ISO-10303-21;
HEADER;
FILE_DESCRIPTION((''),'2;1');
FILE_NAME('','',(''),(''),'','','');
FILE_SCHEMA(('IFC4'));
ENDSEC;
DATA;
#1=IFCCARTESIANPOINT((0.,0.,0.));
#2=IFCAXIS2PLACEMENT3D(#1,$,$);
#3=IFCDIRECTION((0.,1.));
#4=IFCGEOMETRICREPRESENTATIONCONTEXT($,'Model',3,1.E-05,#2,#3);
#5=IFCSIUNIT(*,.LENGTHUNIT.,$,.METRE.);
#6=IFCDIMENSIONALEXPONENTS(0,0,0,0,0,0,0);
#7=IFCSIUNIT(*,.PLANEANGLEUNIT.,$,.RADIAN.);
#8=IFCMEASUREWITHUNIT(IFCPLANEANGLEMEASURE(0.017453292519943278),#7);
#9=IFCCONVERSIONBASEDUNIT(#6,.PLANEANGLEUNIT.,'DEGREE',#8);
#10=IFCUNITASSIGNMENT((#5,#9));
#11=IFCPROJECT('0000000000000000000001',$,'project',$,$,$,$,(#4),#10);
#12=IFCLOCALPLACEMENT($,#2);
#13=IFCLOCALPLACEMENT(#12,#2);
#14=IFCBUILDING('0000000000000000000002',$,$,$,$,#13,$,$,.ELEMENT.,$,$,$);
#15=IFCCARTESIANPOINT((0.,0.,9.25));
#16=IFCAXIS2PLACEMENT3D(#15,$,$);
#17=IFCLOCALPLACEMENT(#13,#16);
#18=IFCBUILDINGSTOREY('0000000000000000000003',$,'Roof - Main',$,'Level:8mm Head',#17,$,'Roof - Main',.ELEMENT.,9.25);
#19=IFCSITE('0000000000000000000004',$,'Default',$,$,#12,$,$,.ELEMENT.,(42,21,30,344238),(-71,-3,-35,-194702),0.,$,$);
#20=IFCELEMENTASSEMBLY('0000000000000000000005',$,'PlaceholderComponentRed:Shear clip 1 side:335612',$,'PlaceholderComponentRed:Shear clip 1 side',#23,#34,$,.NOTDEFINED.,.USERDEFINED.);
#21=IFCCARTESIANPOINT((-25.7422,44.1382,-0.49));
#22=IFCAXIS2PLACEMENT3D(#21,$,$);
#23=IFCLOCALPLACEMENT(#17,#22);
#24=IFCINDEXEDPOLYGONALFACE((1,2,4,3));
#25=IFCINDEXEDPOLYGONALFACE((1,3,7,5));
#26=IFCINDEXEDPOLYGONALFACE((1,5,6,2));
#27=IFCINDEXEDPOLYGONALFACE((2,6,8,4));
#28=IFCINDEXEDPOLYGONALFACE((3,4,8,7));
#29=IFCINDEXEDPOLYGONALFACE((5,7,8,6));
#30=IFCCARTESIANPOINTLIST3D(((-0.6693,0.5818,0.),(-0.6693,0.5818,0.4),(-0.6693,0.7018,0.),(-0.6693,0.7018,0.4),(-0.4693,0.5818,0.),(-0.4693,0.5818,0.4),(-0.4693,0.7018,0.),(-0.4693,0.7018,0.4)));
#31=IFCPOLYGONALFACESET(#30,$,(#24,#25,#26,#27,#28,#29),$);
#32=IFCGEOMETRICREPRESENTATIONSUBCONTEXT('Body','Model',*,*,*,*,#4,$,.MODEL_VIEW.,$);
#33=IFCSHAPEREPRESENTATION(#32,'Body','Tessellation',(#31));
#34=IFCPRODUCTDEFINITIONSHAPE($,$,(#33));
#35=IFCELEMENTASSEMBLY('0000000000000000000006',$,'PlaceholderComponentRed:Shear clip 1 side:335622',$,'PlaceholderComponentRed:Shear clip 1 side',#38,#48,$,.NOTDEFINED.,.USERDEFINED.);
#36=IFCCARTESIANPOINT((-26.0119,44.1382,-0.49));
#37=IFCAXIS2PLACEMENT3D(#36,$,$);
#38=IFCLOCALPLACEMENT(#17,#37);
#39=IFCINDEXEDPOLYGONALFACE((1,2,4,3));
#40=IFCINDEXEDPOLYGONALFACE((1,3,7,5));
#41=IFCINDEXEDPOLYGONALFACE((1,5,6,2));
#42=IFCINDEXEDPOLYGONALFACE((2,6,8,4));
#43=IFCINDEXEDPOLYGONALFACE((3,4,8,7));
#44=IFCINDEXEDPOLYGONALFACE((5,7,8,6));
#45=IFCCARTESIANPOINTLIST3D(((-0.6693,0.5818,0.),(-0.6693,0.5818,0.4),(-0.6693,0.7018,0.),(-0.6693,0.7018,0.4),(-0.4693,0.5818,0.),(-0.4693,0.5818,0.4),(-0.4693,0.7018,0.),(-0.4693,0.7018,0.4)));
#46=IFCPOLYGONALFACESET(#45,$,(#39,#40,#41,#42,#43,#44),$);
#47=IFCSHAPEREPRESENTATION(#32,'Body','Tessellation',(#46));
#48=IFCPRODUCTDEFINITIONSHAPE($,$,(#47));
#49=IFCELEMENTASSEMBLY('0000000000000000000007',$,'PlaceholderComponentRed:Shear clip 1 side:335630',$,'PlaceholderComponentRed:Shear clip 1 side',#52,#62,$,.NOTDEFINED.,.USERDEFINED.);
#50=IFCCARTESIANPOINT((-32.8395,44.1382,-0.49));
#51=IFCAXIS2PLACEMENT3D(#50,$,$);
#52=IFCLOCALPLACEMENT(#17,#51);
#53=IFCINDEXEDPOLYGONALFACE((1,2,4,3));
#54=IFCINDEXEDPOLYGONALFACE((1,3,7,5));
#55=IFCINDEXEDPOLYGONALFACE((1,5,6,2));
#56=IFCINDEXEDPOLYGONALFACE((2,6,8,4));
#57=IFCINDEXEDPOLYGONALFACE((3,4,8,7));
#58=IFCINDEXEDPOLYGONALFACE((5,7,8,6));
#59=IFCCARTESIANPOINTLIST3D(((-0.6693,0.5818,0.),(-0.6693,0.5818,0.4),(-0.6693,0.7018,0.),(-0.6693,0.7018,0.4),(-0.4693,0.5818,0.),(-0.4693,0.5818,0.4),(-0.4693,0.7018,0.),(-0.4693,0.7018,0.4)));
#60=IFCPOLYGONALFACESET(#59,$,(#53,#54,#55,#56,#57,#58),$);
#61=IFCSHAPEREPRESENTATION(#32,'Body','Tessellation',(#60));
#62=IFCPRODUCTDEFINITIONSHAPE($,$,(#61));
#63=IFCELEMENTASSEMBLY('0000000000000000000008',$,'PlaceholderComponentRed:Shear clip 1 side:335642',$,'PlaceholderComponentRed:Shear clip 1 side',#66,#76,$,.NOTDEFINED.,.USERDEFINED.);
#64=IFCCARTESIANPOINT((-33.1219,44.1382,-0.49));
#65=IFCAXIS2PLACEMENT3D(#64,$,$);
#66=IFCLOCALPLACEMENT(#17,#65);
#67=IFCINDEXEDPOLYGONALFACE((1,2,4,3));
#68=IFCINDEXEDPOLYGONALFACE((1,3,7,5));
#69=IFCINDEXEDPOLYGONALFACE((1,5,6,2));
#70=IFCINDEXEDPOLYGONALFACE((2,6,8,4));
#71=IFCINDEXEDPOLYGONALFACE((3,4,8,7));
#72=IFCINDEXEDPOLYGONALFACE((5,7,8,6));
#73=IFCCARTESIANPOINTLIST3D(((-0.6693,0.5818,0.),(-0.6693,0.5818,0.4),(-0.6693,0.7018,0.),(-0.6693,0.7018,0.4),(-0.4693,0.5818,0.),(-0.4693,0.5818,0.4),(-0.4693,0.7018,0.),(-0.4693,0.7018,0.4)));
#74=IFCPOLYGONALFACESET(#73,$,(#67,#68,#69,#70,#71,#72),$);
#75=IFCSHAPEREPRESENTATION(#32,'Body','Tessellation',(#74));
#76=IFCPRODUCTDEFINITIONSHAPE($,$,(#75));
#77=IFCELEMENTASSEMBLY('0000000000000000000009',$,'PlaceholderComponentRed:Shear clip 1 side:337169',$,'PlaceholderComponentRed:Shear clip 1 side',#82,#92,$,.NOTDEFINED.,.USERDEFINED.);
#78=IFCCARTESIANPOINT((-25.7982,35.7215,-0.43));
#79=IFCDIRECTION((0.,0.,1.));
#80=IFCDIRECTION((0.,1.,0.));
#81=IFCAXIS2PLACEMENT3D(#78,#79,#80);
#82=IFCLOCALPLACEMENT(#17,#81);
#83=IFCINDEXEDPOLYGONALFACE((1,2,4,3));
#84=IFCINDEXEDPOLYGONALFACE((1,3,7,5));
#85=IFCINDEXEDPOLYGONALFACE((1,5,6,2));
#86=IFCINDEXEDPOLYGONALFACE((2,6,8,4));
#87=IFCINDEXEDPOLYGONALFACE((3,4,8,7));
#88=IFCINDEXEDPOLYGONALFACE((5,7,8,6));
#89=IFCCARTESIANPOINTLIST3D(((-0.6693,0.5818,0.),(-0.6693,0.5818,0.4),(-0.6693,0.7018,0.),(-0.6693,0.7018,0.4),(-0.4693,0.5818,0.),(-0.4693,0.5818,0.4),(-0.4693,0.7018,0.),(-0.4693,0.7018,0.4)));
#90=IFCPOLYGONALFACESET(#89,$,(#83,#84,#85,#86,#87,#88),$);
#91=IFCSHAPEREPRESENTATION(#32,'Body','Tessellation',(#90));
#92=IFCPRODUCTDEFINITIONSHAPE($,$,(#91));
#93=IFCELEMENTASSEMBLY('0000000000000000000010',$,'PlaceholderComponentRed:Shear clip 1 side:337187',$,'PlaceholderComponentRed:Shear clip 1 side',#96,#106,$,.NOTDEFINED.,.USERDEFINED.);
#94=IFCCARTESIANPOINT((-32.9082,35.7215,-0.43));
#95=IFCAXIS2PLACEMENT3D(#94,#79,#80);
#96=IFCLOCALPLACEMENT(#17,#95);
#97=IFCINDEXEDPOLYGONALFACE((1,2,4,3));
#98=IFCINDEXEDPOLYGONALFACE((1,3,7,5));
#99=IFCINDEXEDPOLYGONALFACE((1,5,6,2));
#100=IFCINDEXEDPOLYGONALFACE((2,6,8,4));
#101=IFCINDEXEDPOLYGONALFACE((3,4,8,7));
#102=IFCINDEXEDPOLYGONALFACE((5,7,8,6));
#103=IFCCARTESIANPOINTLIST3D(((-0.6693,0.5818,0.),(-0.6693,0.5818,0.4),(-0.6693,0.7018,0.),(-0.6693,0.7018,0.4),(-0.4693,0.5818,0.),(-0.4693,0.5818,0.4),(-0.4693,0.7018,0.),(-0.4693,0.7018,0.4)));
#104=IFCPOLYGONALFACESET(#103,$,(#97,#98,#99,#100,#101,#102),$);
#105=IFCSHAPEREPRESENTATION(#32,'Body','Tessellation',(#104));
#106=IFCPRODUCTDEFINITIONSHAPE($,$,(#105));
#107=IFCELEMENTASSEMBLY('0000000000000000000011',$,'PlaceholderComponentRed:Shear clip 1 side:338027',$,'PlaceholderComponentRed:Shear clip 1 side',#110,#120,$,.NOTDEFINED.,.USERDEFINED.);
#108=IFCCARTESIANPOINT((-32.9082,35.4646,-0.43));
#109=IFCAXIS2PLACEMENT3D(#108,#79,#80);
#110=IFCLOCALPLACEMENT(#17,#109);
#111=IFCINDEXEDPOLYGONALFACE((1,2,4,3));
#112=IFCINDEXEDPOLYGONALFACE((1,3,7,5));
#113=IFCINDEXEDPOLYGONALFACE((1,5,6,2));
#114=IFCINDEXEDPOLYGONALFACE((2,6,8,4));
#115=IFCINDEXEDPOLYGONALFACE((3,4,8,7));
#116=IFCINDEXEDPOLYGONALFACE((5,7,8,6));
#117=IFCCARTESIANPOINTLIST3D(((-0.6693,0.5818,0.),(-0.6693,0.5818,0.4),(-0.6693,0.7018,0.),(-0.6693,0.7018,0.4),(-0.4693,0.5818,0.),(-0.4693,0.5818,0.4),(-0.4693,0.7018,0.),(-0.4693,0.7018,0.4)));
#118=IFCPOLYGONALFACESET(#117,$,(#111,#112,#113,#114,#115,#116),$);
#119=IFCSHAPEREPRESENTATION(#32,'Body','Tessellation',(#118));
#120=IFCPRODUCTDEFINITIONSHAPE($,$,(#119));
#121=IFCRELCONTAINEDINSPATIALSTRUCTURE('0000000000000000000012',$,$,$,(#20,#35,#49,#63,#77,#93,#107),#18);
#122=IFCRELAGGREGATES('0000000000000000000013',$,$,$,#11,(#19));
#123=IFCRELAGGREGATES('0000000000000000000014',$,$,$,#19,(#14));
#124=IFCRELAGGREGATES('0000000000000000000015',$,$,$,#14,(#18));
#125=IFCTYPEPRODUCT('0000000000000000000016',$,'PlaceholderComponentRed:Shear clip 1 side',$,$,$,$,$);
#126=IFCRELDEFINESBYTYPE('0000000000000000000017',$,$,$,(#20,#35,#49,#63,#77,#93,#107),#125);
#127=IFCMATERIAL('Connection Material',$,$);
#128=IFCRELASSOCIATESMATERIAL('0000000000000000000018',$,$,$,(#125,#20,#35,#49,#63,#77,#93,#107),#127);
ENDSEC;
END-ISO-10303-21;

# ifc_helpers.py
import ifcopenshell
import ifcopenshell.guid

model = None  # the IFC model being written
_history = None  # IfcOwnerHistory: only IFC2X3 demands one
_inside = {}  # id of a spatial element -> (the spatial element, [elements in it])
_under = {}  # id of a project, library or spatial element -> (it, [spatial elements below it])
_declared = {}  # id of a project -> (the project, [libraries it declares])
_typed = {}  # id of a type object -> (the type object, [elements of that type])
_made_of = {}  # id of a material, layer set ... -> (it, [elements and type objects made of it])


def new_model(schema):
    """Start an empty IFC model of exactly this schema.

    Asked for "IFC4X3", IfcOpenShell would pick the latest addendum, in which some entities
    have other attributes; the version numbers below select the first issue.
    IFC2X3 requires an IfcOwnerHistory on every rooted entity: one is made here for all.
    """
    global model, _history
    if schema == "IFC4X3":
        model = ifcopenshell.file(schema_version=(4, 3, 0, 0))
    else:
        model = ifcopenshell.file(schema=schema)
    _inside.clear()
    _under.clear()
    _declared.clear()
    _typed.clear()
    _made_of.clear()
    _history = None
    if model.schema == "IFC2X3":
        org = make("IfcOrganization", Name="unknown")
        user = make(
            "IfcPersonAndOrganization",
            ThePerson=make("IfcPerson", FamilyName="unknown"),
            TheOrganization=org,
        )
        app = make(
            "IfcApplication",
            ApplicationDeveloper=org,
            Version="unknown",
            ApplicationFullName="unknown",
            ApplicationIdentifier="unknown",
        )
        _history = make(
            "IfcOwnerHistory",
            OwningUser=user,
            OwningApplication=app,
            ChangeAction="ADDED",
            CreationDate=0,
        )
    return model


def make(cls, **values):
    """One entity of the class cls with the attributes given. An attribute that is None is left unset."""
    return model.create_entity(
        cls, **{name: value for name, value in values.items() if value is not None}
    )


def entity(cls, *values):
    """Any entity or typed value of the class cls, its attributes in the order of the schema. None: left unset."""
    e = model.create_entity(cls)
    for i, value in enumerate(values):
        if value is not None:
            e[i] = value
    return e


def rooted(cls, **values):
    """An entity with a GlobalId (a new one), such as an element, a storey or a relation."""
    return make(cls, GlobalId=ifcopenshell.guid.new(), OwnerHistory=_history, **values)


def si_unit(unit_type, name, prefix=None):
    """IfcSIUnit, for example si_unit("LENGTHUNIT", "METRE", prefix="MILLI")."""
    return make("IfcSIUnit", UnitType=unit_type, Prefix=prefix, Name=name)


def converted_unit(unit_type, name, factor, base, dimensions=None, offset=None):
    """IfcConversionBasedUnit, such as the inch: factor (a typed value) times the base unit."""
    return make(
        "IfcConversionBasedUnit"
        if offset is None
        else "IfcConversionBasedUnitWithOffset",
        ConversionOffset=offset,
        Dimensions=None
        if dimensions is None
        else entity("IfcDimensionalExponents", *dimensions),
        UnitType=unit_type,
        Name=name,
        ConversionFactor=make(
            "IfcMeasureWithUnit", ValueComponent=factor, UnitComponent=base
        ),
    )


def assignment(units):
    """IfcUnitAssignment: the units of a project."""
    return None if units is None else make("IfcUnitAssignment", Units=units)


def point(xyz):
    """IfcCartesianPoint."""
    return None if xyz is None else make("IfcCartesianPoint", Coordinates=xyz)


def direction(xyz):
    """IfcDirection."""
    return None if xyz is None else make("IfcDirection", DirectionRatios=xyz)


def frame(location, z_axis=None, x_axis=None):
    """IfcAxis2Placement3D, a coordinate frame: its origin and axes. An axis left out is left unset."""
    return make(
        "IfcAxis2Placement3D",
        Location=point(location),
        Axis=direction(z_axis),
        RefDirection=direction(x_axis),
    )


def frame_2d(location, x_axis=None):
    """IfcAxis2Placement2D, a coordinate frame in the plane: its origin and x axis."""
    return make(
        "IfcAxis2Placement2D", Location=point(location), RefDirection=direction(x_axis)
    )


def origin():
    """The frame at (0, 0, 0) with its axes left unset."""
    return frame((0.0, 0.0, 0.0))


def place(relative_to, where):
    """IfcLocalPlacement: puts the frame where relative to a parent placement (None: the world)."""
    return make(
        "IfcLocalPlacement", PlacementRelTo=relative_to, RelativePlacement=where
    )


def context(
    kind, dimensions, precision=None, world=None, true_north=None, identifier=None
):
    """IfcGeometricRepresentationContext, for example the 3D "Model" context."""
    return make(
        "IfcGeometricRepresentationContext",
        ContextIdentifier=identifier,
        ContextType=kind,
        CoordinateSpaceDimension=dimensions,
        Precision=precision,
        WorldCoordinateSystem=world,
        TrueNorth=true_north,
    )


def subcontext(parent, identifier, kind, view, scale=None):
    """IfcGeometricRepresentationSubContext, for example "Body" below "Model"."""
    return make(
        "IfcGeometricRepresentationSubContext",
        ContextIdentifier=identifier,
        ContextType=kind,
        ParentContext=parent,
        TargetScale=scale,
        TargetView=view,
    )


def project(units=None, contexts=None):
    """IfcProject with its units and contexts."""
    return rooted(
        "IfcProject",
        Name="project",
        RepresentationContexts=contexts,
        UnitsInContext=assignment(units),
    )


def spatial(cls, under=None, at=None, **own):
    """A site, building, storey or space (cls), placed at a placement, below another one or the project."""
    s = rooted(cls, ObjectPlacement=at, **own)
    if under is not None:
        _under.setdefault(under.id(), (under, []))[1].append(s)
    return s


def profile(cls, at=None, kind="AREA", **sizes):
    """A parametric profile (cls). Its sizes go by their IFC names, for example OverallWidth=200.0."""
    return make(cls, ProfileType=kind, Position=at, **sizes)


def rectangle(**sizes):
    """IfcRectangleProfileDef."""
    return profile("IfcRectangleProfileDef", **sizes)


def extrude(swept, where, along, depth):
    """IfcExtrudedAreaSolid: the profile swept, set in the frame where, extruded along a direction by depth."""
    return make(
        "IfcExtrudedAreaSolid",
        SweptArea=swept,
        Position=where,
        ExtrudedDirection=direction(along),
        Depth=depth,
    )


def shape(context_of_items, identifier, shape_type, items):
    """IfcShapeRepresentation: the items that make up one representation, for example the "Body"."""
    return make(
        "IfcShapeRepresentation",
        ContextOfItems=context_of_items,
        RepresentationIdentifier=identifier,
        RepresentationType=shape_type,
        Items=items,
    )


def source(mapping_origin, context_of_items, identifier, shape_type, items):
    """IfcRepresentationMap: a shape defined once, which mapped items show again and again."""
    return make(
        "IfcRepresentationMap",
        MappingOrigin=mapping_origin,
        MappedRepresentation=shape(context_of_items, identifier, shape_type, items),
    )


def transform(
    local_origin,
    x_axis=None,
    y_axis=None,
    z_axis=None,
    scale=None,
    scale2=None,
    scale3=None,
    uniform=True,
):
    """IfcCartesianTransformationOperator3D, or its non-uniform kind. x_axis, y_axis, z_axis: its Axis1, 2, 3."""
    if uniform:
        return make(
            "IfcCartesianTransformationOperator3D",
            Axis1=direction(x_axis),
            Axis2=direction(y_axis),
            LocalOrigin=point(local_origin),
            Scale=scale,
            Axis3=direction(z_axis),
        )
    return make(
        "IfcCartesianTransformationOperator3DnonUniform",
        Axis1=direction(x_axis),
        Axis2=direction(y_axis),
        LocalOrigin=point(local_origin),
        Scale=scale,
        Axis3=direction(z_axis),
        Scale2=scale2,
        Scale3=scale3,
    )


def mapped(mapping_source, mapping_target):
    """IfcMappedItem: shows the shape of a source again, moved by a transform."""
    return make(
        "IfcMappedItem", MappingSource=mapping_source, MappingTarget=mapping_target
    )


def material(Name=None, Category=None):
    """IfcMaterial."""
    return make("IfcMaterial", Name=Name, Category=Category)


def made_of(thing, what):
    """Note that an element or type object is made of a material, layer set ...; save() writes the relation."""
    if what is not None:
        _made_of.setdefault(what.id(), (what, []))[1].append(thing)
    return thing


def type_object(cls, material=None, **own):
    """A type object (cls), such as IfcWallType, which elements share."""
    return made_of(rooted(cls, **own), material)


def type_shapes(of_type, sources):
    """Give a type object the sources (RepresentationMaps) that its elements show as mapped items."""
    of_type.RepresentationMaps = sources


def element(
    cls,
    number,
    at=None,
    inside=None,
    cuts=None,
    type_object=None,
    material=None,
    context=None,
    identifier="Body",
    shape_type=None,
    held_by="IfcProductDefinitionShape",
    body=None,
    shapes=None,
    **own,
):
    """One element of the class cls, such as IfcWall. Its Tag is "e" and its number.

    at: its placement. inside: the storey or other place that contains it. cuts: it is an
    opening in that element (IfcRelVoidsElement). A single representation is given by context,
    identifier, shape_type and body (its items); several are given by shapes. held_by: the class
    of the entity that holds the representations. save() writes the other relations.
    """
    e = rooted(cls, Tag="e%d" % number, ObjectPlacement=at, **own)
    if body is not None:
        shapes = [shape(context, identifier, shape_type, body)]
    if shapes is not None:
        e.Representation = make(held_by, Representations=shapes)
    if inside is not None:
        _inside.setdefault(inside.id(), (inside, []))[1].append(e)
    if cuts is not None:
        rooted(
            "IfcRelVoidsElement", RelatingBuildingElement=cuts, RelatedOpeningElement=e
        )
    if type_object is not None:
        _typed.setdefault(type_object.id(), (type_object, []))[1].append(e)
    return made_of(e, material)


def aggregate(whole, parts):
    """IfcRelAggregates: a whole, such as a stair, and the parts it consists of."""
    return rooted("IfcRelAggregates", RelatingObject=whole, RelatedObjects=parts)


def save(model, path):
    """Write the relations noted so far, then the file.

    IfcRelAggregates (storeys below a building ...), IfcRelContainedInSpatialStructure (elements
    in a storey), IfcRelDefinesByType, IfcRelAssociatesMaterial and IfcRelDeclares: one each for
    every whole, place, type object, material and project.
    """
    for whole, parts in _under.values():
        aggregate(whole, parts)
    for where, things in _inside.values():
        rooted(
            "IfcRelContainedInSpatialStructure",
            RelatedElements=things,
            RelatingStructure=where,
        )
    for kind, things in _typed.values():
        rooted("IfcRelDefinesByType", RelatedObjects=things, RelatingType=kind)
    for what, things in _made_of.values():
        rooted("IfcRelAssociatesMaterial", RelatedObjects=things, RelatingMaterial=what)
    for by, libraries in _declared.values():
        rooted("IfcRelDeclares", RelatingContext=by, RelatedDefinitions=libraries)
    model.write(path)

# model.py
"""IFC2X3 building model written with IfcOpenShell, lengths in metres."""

from ifc_helpers import new_model, entity, si_unit, converted_unit, direction, frame, frame_2d, origin, place, context, subcontext, project, spatial, rectangle, extrude, source, transform, mapped, material, type_object, type_shapes, element, save


model = new_model("IFC2X3")

# Units and contexts
model_context = context("Model", 3, precision=1e-05, world=origin(), true_north=direction((0.0, 1.0)))
body_context = subcontext(model_context, "Body", "Model", "MODEL_VIEW")
ifc_project = project(units=[si_unit("LENGTHUNIT", "METRE"), converted_unit("PLANEANGLEUNIT", "DEGREE", entity("IfcPlaneAngleMeasure", 0.017453292519943278), si_unit("PLANEANGLEUNIT", "RADIAN"), dimensions=[0, 0, 0, 0, 0, 0, 0])], contexts=[model_context])

# Site, building, storey
site_placement = place(None, origin())
site = spatial("IfcSite", under=ifc_project, at=site_placement, Name="Default", CompositionType="ELEMENT", RefLatitude=(42, 21, 30, 344238), RefLongitude=(-71, -3, -35, -194702), RefElevation=0.0)
building_placement = place(site_placement, origin())
building = spatial("IfcBuilding", under=site, at=building_placement, CompositionType="ELEMENT")
storey_placement = place(building_placement, frame((0.0, 0.0, 9.25)))
storey = spatial("IfcBuildingStorey", under=building, at=storey_placement, Name="Roof - Main", ObjectType="Level:8mm Head", LongName="Roof - Main", CompositionType="ELEMENT", Elevation=9.25)

# Element assemblies
ifc_material_1 = material(Name="Connection Material")
type_product = type_object("IfcTypeProduct", Name="PlaceholderComponentRed:Shear clip 1 side", material=ifc_material_1)
shared_shape_1 = source(origin(), body_context, "Body", "SweptSolid", [
    extrude(rectangle(XDim=0.12, YDim=0.2, at=frame_2d((0.0, 0.0), x_axis=(1.0, 0.0))), frame((-0.5693, 0.6418, 0.0), z_axis=(0.0, 0.0, 1.0), x_axis=(0.0, 1.0, 0.0)), (0.0, 0.0, 1.0), 0.4),
])
type_shapes(type_product, [shared_shape_1])
for number, where, name in (
    (1, (-25.7422, 44.1382, -0.49), "PlaceholderComponentRed:Shear clip 1 side:335612"),
    (2, (-26.0119, 44.1382, -0.49), "PlaceholderComponentRed:Shear clip 1 side:335622"),
    (3, (-32.8395, 44.1382, -0.49), "PlaceholderComponentRed:Shear clip 1 side:335630"),
    (4, (-33.1219, 44.1382, -0.49), "PlaceholderComponentRed:Shear clip 1 side:335642"),
):
    element("IfcElementAssembly", number, at=place(storey_placement, frame(where)), inside=storey, type_object=type_product, material=ifc_material_1, Name=name, ObjectType="PlaceholderComponentRed:Shear clip 1 side", AssemblyPlace="NOTDEFINED", PredefinedType="USERDEFINED", context=body_context, shape_type="MappedRepresentation", body=[
        mapped(shared_shape_1, transform((0.0, 0.0, 0.0), scale=1.0)),
    ])
for number, where, z_axis, x_axis, name in (
    (5, (-25.7982, 35.7215, -0.43), (0.0, 0.0, 1.0), (0.0, 1.0, 0.0), "PlaceholderComponentRed:Shear clip 1 side:337169"),
    (6, (-32.9082, 35.7215, -0.43), (0.0, 0.0, 1.0), (0.0, 1.0, 0.0), "PlaceholderComponentRed:Shear clip 1 side:337187"),
    (7, (-32.9082, 35.4646, -0.43), (0.0, 0.0, 1.0), (0.0, 1.0, 0.0), "PlaceholderComponentRed:Shear clip 1 side:338027"),
):
    element("IfcElementAssembly", number, at=place(storey_placement, frame(where, z_axis=z_axis, x_axis=x_axis)), inside=storey, type_object=type_product, material=ifc_material_1, Name=name, ObjectType="PlaceholderComponentRed:Shear clip 1 side", AssemblyPlace="NOTDEFINED", PredefinedType="USERDEFINED", context=body_context, shape_type="MappedRepresentation", body=[
        mapped(shared_shape_1, transform((0.0, 0.0, 0.0), scale=1.0)),
    ])

save(model, "model.ifc")
